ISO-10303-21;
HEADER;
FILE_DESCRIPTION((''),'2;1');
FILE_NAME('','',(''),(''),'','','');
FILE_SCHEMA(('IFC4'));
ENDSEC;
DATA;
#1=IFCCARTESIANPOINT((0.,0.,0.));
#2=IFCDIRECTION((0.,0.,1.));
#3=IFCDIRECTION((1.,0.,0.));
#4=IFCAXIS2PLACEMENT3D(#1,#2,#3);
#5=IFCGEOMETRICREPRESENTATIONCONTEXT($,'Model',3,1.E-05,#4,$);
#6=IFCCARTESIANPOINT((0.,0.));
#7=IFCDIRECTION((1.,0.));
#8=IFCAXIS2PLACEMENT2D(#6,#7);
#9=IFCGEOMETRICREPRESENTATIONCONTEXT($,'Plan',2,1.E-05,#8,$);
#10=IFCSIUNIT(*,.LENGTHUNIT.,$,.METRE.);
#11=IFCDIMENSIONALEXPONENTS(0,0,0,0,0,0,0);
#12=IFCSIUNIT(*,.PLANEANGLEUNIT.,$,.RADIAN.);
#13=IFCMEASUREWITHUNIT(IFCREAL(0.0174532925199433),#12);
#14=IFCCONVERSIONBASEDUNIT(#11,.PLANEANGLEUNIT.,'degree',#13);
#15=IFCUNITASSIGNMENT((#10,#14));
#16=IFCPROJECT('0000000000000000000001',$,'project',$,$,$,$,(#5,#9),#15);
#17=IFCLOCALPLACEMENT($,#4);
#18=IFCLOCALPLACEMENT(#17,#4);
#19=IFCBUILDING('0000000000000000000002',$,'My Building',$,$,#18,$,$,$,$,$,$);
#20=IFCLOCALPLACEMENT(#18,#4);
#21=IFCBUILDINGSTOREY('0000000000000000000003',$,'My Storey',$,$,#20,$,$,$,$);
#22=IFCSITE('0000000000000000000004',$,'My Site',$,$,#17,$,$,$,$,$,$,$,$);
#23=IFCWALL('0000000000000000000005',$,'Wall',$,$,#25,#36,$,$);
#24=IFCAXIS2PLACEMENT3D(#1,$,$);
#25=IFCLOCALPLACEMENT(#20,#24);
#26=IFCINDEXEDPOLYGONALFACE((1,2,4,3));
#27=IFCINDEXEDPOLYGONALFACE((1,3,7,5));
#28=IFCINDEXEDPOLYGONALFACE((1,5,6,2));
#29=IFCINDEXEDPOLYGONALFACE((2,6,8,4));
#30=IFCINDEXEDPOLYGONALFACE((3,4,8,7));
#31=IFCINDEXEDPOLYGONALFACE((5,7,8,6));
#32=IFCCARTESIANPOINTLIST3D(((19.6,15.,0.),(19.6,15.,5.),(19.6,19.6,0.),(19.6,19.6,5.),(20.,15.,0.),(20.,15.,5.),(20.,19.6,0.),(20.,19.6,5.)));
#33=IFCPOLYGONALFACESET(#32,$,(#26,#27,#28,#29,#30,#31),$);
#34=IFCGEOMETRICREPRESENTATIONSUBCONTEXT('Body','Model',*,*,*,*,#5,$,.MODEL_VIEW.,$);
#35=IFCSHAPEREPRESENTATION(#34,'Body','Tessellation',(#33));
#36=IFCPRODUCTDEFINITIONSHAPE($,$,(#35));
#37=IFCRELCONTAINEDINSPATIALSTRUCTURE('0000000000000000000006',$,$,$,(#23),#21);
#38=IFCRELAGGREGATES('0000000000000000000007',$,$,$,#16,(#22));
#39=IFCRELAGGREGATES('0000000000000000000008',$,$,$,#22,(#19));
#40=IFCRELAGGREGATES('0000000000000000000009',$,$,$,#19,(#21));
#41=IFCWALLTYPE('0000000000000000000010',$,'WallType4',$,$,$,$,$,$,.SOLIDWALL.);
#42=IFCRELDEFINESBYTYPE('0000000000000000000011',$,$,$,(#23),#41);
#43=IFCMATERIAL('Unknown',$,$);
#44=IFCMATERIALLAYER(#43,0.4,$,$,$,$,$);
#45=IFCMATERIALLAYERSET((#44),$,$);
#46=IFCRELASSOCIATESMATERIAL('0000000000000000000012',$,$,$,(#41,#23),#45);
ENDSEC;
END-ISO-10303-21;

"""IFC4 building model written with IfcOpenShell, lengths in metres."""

from ifc_helpers import new_model, entity, si_unit, converted_unit, frame, origin_with_axes, origin_2d_with_axis, place, context, subcontext, project, spatial, indexed_curve, outline, extrude, material, layer, layer_set, layer_usage, type_object, element, save


model = new_model("IFC4")

# Units and contexts
model_context = context("Model", 3, precision=1e-05, world=origin_with_axes())
plan_context = context("Plan", 2, precision=1e-05, world=origin_2d_with_axis())
body_context_1 = subcontext(model_context, "Body", "Model", "MODEL_VIEW")
ifc_project = project(units=[si_unit("LENGTHUNIT", "METRE"), converted_unit("PLANEANGLEUNIT", "degree", entity("IfcReal", 0.0174532925199433), si_unit("PLANEANGLEUNIT", "RADIAN"), dimensions=[0, 0, 0, 0, 0, 0, 0])], contexts=[model_context, plan_context])

# Site, building, storey
site_placement = place(None, origin_with_axes())
site = spatial("IfcSite", under=ifc_project, at=site_placement, Name="My Site")
building_placement = place(site_placement, origin_with_axes())
building = spatial("IfcBuilding", under=site, at=building_placement, Name="My Building")
storey_placement = place(building_placement, origin_with_axes())
storey = spatial("IfcBuildingStorey", under=building, at=storey_placement, Name="My Storey")

# Shared definitions
ifc_material = material(Name="Unknown")
ifc_layer = layer(ifc_material, 0.4)
ifc_layer_set = layer_set([ifc_layer])
wall_type = type_object("IfcWallType", Name="WallType4", PredefinedType="SOLIDWALL", material=ifc_layer_set)

# Wall
ifc_layer_usage_1 = layer_usage(ifc_layer_set, "AXIS2", "POSITIVE", 0.0)
wall_1_placement = place(storey_placement, frame((19.6, 19.6, 0.0), z_axis=(0.0, 0.0, 1.0), x_axis=(0.0, -1.0, 0.0)))
element("IfcWall", 1, at=wall_1_placement, inside=storey, type_object=wall_type, material=ifc_layer_usage_1, Name="Wall", context=body_context_1, shape_type="SweptSolid", body=[
    extrude(outline(indexed_curve([(0.0, 0.0), (0.0, 0.4), (4.6, 0.4), (4.6, 0.0), (0.0, 0.0)], self_intersect=False)), origin_with_axes(), (0.0, 0.0, 1.0), 5.0),
])

save(model, "model.ifc")
